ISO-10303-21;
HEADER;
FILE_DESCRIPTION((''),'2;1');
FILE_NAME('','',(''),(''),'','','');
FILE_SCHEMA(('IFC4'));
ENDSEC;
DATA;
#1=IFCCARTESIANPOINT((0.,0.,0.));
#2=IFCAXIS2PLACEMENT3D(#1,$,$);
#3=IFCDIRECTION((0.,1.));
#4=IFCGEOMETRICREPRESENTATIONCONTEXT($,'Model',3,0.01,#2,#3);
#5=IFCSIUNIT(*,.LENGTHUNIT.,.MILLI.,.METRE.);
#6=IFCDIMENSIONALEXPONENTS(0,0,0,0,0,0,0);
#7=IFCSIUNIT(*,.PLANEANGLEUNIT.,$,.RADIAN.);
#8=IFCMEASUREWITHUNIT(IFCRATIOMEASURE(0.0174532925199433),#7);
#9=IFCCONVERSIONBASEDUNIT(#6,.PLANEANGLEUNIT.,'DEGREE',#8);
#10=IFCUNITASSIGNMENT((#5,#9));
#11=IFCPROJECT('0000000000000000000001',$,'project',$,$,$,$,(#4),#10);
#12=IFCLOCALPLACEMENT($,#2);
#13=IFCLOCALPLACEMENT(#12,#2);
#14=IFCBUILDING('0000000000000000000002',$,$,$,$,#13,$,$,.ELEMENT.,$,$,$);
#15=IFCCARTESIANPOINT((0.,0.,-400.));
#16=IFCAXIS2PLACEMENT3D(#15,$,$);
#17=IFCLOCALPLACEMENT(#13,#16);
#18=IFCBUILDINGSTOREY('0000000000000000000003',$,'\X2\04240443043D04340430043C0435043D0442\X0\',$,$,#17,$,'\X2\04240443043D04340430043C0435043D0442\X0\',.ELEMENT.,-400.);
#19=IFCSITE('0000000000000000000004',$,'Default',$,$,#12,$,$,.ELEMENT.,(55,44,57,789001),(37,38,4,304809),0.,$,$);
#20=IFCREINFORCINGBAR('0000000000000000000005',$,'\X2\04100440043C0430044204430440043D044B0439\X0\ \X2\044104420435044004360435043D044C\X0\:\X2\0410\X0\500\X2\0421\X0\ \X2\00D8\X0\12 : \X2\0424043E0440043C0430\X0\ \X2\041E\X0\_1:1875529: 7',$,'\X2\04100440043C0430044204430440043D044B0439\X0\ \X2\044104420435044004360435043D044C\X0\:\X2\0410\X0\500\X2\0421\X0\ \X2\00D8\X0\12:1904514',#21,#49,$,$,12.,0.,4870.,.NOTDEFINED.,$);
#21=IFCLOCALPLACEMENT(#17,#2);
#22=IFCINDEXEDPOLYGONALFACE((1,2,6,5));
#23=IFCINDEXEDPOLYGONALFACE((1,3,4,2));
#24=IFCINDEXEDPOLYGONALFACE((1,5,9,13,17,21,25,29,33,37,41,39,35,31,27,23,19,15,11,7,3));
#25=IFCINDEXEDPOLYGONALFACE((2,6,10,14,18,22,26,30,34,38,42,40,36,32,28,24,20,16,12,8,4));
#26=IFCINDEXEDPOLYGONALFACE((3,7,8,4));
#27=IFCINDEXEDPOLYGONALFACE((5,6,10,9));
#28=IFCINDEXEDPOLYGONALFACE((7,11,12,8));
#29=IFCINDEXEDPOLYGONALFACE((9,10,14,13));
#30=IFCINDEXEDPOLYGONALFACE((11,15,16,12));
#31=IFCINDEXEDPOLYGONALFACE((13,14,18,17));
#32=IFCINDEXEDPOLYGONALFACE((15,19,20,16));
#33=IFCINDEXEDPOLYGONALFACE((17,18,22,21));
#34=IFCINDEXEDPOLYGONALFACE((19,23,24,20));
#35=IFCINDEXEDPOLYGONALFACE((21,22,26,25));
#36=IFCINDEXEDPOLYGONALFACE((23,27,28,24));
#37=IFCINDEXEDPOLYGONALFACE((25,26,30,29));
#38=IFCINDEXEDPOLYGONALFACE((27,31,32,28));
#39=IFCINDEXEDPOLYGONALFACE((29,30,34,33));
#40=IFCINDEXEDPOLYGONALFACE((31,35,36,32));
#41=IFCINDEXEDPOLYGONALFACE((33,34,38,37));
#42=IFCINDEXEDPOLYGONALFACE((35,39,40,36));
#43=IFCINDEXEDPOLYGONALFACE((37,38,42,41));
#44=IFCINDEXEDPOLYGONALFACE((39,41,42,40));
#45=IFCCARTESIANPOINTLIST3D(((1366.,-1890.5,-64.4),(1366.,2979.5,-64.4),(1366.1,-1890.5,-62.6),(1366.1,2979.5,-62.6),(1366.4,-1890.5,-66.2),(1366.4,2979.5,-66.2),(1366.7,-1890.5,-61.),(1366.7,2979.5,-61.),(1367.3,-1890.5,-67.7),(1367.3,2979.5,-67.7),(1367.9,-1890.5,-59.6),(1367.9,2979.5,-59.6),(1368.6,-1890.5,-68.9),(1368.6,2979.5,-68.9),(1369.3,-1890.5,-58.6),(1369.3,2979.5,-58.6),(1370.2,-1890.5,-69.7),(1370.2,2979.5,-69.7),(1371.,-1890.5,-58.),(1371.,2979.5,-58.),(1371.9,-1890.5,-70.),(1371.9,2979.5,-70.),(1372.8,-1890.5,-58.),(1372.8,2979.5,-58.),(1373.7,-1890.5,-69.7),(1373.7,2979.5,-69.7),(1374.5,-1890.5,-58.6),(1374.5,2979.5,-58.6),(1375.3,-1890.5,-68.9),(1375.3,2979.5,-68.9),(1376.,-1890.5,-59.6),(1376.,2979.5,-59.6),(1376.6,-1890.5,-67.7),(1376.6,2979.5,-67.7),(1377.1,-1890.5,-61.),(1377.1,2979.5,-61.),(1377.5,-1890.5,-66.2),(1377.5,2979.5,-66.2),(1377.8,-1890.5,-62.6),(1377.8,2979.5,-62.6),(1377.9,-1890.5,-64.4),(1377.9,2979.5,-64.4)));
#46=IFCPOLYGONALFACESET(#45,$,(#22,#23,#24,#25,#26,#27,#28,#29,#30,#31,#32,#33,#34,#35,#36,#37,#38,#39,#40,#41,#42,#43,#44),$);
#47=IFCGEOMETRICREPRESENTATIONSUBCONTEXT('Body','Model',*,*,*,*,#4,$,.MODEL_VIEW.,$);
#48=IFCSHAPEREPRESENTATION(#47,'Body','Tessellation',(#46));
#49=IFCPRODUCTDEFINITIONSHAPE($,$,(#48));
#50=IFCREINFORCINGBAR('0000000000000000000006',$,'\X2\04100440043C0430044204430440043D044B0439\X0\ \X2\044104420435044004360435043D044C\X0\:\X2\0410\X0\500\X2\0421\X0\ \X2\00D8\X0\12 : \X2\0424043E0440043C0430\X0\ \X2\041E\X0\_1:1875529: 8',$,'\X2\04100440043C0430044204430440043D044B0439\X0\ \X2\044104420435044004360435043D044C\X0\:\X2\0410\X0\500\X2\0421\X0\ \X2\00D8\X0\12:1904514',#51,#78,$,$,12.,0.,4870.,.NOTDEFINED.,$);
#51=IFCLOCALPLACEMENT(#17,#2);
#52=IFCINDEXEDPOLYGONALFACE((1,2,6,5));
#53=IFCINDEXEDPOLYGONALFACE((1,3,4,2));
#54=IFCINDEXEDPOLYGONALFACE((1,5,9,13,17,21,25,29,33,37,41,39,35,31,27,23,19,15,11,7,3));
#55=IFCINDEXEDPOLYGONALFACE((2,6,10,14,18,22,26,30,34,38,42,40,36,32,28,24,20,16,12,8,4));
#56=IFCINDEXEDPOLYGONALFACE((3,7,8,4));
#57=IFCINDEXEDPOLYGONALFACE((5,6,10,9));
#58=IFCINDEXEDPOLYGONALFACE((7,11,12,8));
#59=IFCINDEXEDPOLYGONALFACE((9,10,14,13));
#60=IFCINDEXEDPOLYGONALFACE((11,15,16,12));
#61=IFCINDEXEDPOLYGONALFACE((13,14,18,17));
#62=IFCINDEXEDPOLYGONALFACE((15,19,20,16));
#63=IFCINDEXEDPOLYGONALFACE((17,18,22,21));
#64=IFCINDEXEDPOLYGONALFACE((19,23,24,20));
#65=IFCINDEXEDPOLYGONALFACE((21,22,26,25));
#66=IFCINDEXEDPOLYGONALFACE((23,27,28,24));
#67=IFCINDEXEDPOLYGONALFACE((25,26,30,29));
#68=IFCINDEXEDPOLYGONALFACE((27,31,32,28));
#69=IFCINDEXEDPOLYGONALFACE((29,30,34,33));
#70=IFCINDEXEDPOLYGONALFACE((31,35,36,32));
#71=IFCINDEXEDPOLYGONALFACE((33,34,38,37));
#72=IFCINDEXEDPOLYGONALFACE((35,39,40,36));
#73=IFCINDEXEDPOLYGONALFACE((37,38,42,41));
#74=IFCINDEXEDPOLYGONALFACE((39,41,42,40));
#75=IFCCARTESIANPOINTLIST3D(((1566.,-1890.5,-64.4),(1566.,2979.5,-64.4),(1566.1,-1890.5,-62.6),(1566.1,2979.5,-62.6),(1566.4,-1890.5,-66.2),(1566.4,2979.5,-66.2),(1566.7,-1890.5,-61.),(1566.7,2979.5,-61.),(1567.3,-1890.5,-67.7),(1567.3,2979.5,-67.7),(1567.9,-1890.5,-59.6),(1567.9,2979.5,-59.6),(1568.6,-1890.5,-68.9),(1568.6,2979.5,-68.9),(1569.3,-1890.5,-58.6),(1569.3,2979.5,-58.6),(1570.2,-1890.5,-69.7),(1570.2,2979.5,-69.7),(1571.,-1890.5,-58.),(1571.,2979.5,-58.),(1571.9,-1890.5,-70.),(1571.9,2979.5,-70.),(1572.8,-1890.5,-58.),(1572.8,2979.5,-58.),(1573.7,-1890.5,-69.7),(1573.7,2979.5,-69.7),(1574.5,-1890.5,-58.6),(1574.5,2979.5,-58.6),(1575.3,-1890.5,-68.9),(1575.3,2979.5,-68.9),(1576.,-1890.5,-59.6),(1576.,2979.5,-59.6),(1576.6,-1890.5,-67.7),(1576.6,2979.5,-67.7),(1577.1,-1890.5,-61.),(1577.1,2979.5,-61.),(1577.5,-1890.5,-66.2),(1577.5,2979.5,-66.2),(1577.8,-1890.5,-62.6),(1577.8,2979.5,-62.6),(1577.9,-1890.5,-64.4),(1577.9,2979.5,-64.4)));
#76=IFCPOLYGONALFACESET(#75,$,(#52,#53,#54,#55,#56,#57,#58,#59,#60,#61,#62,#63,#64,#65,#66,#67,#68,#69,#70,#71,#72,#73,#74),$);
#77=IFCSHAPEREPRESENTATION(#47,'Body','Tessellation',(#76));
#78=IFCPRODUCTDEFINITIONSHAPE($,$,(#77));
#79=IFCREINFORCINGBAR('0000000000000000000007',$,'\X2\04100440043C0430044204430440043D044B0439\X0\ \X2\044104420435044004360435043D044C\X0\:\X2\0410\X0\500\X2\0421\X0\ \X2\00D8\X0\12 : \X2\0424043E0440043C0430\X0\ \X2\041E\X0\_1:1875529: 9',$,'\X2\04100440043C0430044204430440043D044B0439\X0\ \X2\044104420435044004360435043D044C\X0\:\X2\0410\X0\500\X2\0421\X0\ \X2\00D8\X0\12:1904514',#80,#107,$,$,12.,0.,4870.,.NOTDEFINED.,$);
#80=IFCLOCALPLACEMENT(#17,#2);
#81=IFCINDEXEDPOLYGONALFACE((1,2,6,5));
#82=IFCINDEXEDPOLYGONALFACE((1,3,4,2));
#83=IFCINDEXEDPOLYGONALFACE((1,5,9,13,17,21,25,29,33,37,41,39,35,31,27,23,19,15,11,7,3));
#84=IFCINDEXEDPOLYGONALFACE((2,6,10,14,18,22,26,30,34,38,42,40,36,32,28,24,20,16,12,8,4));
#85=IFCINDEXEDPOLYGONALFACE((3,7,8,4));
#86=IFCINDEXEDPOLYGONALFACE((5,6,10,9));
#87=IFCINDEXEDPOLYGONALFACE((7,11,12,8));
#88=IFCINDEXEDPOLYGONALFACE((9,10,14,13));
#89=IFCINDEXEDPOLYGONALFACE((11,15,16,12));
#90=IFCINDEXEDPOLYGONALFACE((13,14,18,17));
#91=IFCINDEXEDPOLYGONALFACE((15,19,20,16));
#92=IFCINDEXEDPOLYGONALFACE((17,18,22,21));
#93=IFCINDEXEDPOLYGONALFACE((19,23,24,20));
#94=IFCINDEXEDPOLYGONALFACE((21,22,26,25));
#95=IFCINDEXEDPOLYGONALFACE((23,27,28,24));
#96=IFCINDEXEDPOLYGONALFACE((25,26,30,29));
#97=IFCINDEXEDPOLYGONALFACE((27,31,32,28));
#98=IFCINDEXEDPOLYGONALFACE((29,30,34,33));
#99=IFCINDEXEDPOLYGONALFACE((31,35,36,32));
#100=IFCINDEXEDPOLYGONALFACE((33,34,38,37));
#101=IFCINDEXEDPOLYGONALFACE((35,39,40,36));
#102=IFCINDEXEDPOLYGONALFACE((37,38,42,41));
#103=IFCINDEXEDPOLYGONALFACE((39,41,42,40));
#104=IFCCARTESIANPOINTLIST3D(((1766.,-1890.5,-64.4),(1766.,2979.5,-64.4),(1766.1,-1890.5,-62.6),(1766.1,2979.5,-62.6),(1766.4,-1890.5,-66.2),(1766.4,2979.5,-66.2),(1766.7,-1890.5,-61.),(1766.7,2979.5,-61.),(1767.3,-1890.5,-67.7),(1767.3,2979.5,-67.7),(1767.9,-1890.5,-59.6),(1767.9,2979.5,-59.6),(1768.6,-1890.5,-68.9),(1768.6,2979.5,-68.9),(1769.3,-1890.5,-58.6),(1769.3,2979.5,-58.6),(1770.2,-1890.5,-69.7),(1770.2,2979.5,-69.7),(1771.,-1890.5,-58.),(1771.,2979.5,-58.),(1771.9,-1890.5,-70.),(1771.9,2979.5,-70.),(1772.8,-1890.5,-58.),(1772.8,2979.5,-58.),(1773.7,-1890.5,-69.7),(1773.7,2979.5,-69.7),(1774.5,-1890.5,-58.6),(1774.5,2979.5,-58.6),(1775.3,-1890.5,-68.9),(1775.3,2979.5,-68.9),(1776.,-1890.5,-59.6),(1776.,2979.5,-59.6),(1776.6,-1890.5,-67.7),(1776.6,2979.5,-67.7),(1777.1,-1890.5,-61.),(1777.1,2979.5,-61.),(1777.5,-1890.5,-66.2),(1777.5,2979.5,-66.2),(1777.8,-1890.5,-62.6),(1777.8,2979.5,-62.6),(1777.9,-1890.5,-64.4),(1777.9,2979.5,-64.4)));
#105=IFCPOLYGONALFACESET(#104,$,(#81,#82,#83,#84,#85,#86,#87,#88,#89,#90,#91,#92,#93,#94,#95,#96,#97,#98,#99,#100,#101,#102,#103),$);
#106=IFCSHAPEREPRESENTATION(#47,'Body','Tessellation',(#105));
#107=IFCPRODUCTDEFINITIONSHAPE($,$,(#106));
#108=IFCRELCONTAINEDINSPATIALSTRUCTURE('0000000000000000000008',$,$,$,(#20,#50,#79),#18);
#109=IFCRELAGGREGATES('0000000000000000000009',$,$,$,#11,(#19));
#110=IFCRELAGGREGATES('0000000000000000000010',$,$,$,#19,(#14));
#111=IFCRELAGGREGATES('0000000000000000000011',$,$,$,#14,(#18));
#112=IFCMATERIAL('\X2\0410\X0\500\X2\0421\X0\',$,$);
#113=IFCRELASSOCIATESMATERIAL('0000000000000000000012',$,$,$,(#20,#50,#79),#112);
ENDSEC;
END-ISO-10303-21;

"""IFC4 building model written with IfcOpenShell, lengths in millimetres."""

from ifc_helpers import new_model, entity, si_unit, converted_unit, direction, frame, origin, place, context, subcontext, project, spatial, material, element, save


model = new_model("IFC4")

# Units and contexts
model_context = context("Model", 3, precision=0.01, world=origin(), true_north=direction((0.0, 1.0)))
body_context = subcontext(model_context, "Body", "Model", "MODEL_VIEW")
ifc_project = project(units=[si_unit("LENGTHUNIT", "METRE", prefix="MILLI"), converted_unit("PLANEANGLEUNIT", "DEGREE", entity("IfcRatioMeasure", 0.0174532925199433), si_unit("PLANEANGLEUNIT", "RADIAN"), dimensions=[0, 0, 0, 0, 0, 0, 0])], contexts=[model_context])

# Site, building, storey
site_placement = place(None, origin())
site = spatial("IfcSite", under=ifc_project, at=site_placement, Name="Default", CompositionType="ELEMENT", RefLatitude=(55, 44, 57, 789001), RefLongitude=(37, 38, 4, 304809), RefElevation=0.0)
building_placement = place(site_placement, origin())
building = spatial("IfcBuilding", under=site, at=building_placement, CompositionType="ELEMENT")
storey_placement = place(building_placement, frame((0.0, 0.0, -400.0)))
storey = spatial("IfcBuildingStorey", under=building, at=storey_placement, Name="Фундамент", LongName="Фундамент", CompositionType="ELEMENT", Elevation=-400.0)

# Reinforcing bars
ifc_material = material(Name="А500С")
reinforcing_bar_1_placement = place(storey_placement, origin())
element("IfcReinforcingBar", 1, at=reinforcing_bar_1_placement, inside=storey, material=ifc_material, Name="Арматурный стержень:А500С Ø12 : Форма О_1:1875529: 7", ObjectType="Арматурный стержень:А500С Ø12:1904514", BarLength=4870.0, CrossSectionArea=0.0, NominalDiameter=12.0, PredefinedType="NOTDEFINED", context=body_context, shape_type="AdvancedSweptSolid", body=[
    entity("IfcSweptDiskSolid", entity("IfcCompositeCurve", [entity("IfcCompositeCurveSegment", "CONTINUOUS", True, entity("IfcPolyline", [entity("IfcCartesianPoint", [1371.9, 2979.5, -64.0]), entity("IfcCartesianPoint", [1371.9, -1890.5, -64.0])]))], False), 6.0, None, 0.0, 1.0),
])
reinforcing_bar_2_placement = place(storey_placement, origin())
element("IfcReinforcingBar", 2, at=reinforcing_bar_2_placement, inside=storey, material=ifc_material, Name="Арматурный стержень:А500С Ø12 : Форма О_1:1875529: 8", ObjectType="Арматурный стержень:А500С Ø12:1904514", BarLength=4870.0, CrossSectionArea=0.0, NominalDiameter=12.0, PredefinedType="NOTDEFINED", context=body_context, shape_type="AdvancedSweptSolid", body=[
    entity("IfcSweptDiskSolid", entity("IfcCompositeCurve", [entity("IfcCompositeCurveSegment", "CONTINUOUS", True, entity("IfcPolyline", [entity("IfcCartesianPoint", [1571.9, 2979.5, -64.0]), entity("IfcCartesianPoint", [1571.9, -1890.5, -64.0])]))], False), 6.0, None, 0.0, 1.0),
])
reinforcing_bar_3_placement = place(storey_placement, origin())
element("IfcReinforcingBar", 3, at=reinforcing_bar_3_placement, inside=storey, material=ifc_material, Name="Арматурный стержень:А500С Ø12 : Форма О_1:1875529: 9", ObjectType="Арматурный стержень:А500С Ø12:1904514", BarLength=4870.0, CrossSectionArea=0.0, NominalDiameter=12.0, PredefinedType="NOTDEFINED", context=body_context, shape_type="AdvancedSweptSolid", body=[
    entity("IfcSweptDiskSolid", entity("IfcCompositeCurve", [entity("IfcCompositeCurveSegment", "CONTINUOUS", True, entity("IfcPolyline", [entity("IfcCartesianPoint", [1771.9, 2979.5, -64.0]), entity("IfcCartesianPoint", [1771.9, -1890.5, -64.0])]))], False), 6.0, None, 0.0, 1.0),
])

save(model, "model.ifc")
